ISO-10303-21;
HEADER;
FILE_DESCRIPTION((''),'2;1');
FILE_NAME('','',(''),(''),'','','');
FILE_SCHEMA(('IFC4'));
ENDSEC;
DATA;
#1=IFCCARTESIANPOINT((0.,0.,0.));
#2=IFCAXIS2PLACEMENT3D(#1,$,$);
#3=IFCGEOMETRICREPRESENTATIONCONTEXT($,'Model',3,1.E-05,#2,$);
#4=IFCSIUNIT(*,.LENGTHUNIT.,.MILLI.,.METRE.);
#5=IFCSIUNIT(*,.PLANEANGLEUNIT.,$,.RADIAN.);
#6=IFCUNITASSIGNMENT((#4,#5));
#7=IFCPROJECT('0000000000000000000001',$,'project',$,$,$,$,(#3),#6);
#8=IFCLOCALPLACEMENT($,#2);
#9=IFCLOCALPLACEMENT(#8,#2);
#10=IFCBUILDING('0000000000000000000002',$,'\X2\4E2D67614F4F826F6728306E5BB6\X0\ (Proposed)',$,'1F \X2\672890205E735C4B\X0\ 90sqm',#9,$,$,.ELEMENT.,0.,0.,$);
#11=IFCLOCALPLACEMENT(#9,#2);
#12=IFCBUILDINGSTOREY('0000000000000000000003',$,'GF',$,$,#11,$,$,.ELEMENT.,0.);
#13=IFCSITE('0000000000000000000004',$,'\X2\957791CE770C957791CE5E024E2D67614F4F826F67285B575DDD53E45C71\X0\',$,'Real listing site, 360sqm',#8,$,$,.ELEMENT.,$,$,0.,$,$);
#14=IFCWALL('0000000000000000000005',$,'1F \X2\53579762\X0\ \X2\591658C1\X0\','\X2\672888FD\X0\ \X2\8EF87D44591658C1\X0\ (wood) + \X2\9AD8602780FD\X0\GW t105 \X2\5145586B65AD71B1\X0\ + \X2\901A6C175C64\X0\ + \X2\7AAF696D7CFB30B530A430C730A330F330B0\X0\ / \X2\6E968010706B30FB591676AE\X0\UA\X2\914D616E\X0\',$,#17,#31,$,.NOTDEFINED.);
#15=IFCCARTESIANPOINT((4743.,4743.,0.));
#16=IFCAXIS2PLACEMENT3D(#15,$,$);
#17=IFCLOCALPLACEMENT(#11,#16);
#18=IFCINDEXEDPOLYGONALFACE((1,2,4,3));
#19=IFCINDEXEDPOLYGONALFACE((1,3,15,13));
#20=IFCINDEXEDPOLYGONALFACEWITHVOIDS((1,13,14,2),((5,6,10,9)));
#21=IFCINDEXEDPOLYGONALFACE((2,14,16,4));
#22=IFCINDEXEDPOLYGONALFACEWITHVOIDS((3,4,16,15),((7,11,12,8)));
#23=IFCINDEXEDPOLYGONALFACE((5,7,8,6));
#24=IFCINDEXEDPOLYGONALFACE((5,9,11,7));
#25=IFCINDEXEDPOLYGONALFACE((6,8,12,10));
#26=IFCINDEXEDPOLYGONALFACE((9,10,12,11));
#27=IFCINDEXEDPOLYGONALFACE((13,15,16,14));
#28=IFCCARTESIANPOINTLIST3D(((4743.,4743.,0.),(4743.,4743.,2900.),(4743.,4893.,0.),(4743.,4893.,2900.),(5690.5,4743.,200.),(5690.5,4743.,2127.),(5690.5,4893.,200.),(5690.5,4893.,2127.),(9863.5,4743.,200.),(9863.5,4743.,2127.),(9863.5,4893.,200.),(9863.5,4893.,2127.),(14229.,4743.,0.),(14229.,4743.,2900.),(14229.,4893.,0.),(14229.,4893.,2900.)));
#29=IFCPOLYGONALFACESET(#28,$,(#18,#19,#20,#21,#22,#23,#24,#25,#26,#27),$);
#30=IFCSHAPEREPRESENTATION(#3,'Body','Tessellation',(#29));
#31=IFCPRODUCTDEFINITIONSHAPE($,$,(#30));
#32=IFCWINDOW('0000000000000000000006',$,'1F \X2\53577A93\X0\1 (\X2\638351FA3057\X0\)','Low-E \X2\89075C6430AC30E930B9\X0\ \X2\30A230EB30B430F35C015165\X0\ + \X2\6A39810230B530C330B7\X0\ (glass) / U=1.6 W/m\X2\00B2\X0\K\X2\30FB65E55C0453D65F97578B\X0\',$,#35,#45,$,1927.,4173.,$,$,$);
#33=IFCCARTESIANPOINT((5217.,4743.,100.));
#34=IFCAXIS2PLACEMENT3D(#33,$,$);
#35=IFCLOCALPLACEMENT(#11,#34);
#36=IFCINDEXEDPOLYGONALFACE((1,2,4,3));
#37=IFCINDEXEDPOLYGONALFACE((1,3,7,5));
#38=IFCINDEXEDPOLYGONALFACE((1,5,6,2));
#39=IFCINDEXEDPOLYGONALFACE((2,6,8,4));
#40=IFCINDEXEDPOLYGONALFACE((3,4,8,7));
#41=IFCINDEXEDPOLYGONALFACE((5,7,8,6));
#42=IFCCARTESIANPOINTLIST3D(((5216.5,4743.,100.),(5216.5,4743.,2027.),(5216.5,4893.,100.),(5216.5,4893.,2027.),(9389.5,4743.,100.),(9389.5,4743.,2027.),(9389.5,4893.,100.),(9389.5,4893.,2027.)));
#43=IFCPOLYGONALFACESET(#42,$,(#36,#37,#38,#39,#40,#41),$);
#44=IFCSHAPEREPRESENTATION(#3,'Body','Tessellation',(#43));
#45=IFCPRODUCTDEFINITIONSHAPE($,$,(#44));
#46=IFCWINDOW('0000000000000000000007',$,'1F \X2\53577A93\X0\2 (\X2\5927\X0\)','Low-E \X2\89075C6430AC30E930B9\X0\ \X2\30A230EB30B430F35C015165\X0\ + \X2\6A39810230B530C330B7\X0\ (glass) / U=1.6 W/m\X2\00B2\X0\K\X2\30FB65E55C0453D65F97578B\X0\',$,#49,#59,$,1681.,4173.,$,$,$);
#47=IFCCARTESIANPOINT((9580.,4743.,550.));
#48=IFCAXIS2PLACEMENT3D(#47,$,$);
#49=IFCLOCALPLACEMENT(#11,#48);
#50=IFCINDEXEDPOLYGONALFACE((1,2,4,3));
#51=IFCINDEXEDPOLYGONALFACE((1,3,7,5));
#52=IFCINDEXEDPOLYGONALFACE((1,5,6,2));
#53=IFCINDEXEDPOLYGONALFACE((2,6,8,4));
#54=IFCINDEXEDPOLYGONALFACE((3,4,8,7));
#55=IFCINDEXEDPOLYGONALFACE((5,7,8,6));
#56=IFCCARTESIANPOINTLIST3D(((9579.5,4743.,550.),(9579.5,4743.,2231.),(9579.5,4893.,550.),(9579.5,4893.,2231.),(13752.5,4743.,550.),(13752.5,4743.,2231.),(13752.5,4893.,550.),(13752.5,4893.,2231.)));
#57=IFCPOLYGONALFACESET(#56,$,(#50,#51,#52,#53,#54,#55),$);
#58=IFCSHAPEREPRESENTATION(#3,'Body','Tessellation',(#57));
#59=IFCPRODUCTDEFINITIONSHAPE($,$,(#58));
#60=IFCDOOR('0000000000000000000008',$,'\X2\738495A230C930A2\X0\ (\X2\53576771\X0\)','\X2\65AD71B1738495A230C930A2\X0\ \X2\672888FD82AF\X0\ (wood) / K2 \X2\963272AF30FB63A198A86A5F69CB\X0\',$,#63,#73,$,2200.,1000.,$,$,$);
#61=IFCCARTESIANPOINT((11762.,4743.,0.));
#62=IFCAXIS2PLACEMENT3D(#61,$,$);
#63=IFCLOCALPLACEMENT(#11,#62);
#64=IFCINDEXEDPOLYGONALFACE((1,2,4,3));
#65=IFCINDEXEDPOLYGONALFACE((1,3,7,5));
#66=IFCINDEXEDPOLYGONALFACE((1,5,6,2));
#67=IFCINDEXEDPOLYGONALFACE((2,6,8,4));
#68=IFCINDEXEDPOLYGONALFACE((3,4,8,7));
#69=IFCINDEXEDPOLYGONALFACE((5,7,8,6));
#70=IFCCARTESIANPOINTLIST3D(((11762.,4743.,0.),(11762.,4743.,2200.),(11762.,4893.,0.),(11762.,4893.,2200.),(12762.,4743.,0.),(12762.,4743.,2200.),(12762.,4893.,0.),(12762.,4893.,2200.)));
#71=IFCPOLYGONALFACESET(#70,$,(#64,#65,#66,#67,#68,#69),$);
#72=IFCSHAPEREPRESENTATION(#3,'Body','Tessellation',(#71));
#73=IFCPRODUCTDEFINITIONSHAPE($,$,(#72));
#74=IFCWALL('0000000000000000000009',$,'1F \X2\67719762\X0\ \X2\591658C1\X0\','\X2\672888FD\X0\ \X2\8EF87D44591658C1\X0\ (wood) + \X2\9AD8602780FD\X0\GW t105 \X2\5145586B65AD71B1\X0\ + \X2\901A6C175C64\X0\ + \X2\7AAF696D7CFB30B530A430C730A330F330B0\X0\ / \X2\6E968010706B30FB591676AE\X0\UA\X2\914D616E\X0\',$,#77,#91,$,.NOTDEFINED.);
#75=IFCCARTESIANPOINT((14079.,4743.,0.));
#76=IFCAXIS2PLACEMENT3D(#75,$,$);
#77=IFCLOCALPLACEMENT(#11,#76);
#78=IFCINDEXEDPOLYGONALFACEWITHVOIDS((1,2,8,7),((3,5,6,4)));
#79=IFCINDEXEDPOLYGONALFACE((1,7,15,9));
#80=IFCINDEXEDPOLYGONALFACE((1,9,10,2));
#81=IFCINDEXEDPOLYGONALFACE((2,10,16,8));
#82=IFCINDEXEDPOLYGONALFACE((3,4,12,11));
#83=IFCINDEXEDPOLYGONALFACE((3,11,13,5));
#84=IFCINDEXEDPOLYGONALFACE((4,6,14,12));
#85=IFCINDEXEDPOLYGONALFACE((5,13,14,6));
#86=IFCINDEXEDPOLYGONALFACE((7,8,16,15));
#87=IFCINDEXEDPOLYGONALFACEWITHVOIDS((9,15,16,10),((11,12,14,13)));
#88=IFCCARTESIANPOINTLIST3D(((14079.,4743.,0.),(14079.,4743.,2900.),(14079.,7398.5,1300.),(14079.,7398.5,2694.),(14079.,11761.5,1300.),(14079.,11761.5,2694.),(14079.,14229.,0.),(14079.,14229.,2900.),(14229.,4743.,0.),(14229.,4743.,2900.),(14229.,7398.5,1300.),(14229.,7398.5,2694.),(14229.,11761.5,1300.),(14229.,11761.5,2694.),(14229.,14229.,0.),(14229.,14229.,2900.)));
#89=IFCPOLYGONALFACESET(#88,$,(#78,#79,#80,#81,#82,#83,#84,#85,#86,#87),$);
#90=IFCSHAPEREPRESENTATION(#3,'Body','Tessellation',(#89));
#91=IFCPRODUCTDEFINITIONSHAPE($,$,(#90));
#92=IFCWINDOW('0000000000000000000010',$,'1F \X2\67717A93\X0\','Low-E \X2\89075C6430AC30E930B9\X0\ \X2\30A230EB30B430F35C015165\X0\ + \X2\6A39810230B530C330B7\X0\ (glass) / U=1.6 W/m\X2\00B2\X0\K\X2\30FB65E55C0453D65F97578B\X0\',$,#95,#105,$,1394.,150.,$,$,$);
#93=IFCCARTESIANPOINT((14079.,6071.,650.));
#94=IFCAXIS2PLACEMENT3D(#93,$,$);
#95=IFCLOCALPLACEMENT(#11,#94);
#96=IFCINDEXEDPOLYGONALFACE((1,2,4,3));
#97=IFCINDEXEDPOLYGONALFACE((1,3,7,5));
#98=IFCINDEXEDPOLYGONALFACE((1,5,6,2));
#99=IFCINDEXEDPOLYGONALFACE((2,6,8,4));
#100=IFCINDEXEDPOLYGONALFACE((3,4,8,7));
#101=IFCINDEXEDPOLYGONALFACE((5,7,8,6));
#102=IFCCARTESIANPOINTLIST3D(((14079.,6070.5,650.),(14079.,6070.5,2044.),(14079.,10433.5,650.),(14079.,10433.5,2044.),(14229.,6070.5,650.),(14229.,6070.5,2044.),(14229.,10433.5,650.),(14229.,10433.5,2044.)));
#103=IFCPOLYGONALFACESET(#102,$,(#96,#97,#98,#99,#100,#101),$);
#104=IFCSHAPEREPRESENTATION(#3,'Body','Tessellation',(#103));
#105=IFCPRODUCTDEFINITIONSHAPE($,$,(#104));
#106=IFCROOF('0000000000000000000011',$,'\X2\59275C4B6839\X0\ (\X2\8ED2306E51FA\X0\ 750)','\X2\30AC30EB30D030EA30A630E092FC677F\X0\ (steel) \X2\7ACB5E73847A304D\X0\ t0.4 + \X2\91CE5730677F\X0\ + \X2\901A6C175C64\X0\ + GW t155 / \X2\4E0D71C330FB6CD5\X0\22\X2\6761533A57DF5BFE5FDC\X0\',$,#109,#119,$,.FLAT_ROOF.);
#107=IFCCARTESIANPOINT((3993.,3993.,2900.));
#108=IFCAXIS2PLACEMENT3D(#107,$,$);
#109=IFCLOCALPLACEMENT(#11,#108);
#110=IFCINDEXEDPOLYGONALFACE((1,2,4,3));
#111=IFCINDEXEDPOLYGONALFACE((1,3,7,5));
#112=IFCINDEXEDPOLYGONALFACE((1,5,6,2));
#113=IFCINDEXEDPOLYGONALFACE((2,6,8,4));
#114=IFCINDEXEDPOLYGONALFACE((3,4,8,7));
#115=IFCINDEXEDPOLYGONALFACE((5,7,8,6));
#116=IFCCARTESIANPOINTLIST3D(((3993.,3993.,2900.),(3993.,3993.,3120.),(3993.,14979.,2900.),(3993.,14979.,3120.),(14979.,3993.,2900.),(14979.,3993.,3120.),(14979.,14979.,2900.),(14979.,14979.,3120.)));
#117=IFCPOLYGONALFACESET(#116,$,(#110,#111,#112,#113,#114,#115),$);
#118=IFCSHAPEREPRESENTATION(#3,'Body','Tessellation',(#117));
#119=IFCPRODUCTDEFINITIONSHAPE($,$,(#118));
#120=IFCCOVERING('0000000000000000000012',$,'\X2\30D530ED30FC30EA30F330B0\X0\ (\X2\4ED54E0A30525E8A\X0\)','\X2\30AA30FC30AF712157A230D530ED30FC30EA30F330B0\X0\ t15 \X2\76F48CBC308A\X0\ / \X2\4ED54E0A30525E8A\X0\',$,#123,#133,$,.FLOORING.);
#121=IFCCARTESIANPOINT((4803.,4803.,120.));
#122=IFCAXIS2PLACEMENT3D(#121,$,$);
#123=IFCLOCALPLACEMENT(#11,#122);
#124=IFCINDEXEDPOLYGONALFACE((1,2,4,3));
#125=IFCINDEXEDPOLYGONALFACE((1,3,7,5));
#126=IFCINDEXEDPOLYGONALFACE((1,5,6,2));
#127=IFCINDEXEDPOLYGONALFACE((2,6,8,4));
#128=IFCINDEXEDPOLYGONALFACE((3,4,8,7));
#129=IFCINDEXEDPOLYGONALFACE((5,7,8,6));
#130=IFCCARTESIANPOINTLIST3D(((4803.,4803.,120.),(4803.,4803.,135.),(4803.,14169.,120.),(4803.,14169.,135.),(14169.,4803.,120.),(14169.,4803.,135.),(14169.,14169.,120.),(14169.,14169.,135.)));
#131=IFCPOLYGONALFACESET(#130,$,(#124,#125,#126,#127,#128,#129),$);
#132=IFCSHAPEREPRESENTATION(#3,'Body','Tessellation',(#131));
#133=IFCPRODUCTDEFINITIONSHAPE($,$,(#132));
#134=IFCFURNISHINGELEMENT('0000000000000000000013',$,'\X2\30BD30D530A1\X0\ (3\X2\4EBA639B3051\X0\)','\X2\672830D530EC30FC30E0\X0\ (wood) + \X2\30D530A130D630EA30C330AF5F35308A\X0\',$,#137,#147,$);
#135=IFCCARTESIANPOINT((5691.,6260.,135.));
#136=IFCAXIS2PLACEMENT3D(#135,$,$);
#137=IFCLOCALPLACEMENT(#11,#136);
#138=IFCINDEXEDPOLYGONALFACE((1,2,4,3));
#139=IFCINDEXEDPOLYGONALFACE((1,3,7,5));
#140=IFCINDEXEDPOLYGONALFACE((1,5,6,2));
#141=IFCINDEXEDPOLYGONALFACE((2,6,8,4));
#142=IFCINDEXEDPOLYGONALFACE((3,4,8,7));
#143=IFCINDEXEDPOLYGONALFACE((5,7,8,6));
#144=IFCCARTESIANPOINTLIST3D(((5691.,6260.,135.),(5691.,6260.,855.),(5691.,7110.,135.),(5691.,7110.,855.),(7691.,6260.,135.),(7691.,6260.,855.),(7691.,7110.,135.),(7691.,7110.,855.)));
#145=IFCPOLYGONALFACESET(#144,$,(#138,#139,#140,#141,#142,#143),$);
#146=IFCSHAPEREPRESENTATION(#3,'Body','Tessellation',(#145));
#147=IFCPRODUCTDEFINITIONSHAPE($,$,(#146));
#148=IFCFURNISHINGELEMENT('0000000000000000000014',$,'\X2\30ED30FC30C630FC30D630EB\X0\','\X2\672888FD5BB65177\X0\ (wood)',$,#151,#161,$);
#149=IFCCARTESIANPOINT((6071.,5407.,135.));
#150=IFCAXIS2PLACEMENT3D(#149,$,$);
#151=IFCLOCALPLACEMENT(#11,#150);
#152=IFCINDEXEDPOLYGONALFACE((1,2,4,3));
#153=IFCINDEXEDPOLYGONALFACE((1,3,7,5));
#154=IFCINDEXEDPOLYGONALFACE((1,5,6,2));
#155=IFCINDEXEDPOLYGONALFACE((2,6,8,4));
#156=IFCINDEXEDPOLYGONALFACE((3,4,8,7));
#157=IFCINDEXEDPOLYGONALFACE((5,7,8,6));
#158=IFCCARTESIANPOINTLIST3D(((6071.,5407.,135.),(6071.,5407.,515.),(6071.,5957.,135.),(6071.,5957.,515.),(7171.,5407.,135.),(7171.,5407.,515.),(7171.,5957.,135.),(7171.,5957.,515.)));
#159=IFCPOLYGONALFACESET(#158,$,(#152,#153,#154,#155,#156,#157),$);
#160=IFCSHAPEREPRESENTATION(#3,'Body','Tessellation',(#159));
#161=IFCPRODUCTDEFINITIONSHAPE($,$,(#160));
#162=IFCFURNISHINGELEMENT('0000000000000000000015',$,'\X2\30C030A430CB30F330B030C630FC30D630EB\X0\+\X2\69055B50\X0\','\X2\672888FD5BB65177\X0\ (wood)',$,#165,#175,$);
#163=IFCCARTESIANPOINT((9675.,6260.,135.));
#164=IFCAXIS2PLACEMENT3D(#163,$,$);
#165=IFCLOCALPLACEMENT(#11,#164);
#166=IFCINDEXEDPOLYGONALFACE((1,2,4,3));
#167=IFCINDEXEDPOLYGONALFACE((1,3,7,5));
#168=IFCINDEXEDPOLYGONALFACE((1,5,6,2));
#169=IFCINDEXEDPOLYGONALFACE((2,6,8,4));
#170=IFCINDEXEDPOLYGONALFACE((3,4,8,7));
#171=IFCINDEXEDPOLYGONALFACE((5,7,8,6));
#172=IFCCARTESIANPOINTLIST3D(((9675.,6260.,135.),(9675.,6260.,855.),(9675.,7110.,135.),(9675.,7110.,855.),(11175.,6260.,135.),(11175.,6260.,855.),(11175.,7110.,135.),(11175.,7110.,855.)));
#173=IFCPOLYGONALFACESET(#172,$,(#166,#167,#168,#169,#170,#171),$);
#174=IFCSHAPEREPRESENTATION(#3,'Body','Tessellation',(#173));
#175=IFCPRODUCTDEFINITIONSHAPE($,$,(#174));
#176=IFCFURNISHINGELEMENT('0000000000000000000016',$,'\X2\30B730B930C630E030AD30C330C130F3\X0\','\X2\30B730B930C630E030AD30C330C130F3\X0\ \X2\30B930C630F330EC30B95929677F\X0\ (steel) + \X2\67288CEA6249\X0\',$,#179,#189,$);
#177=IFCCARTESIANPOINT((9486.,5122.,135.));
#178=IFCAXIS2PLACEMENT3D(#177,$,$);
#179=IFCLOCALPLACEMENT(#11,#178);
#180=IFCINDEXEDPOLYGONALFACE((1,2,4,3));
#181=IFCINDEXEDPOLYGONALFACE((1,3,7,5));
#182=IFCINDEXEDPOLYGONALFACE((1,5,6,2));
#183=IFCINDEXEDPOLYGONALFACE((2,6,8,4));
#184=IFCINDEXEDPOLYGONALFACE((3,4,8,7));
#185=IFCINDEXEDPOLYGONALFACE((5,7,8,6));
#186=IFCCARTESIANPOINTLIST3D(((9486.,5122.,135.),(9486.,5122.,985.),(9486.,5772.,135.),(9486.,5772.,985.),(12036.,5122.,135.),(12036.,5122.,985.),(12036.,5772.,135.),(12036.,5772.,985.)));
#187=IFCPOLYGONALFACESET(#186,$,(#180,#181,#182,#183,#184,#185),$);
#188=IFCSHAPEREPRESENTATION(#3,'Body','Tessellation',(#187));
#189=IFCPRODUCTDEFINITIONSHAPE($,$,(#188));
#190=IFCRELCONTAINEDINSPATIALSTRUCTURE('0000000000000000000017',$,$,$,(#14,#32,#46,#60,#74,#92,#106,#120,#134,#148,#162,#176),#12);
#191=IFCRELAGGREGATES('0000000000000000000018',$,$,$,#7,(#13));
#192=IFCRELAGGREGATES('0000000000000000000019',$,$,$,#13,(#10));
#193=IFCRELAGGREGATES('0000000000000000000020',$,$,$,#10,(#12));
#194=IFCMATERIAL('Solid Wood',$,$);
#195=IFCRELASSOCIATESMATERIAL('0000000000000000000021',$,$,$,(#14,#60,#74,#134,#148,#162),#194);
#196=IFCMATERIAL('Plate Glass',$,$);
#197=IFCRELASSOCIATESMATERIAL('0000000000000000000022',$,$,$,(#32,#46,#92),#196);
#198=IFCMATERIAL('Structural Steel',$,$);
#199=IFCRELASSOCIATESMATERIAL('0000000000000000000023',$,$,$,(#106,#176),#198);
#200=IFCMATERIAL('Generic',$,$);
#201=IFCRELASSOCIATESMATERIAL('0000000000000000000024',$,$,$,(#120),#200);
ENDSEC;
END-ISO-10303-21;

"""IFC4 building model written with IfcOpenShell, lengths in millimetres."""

from ifc_helpers import new_model, si_unit, frame, frame_2d, origin, place, context, project, spatial, rectangle, extrude, material, element, fill, save


model = new_model("IFC4")

# Units and contexts
model_context = context("Model", 3, precision=1e-05, world=origin())
ifc_project = project(units=[si_unit("LENGTHUNIT", "METRE", prefix="MILLI"), si_unit("PLANEANGLEUNIT", "RADIAN")], contexts=[model_context])

# Site, building, storey
site_placement = place(None, origin())
site = spatial("IfcSite", under=ifc_project, at=site_placement, Name="長野県長野市中条住良木字川古山", ObjectType="Real listing site, 360sqm", CompositionType="ELEMENT", RefElevation=0.0)
building_placement = place(site_placement, origin())
building = spatial("IfcBuilding", under=site, at=building_placement, Name="中条住良木の家 (Proposed)", ObjectType="1F 木造平屋 90sqm", CompositionType="ELEMENT", ElevationOfRefHeight=0.0, ElevationOfTerrain=0.0)
storey_placement = place(building_placement, origin())
storey = spatial("IfcBuildingStorey", under=building, at=storey_placement, Name="GF", CompositionType="ELEMENT", Elevation=0.0)

# Shared definitions
ifc_material_1 = material(Name="Solid Wood")

# Wall, openings, windows, door
wall_1_placement = place(storey_placement, frame((4743.0, 4743.0, 0.0)))
wall_1 = element("IfcWall", 1, at=wall_1_placement, inside=storey, material=ifc_material_1, Name="1F 南面 外壁", Description="木製 軸組外壁 (wood) + 高性能GW t105 充填断熱 + 通気層 + 窯業系サイディング / 準耐火・外皮UA配慮", PredefinedType="NOTDEFINED", context=model_context, shape_type="SweptSolid", body=[
    extrude(rectangle(XDim=9486.0, YDim=150.0, at=frame_2d((4743.0, 75.0))), frame((4743.0, 4743.0, 0.0)), (0.0, 0.0, 1.0), 2900.0),
])
opening_1_placement = place(storey_placement, frame((5217.0, 4743.0, 100.0)))
opening_1 = element("IfcOpeningElement", 2, at=opening_1_placement, cuts=wall_1, PredefinedType="NOTDEFINED", context=model_context, shape_type="SweptSolid", body=[
    extrude(rectangle(XDim=4173.0, YDim=150.0, at=frame_2d((2086.0, 75.0))), frame((5217.0, 4743.0, 100.0)), (0.0, 0.0, 1.0), 1927.0),
])
opening_2_placement = place(storey_placement, frame((9580.0, 4743.0, 550.0)))
opening_2 = element("IfcOpeningElement", 3, at=opening_2_placement, cuts=wall_1, PredefinedType="NOTDEFINED", context=model_context, shape_type="SweptSolid", body=[
    extrude(rectangle(XDim=4173.0, YDim=150.0, at=frame_2d((2086.0, 75.0))), frame((9580.0, 4743.0, 550.0)), (0.0, 0.0, 1.0), 1681.0),
])
opening_3_placement = place(storey_placement, frame((11762.0, 4743.0, 0.0)))
opening_3 = element("IfcOpeningElement", 4, at=opening_3_placement, cuts=wall_1, PredefinedType="NOTDEFINED", context=model_context, shape_type="SweptSolid", body=[
    extrude(rectangle(XDim=1000.0, YDim=150.0, at=frame_2d((500.0, 75.0))), frame((11762.0, 4743.0, 0.0)), (0.0, 0.0, 1.0), 2200.0),
])
ifc_material_2 = material(Name="Plate Glass")
window_1_placement = place(storey_placement, frame((5217.0, 4743.0, 100.0)))
window_1 = element("IfcWindow", 5, at=window_1_placement, inside=storey, material=ifc_material_2, Name="1F 南窓1 (掃出し)", Description="Low-E 複層ガラス アルゴン封入 + 樹脂サッシ (glass) / U=1.6 W/m²K・日射取得型", OverallHeight=1927.0, OverallWidth=4173.0, context=model_context, shape_type="SweptSolid", body=[
    extrude(rectangle(XDim=4173.0, YDim=150.0, at=frame_2d((2086.0, 75.0))), frame((5217.0, 4743.0, 100.0)), (0.0, 0.0, 1.0), 1927.0),
])
fill(opening_1, window_1)
window_2_placement = place(storey_placement, frame((9580.0, 4743.0, 550.0)))
window_2 = element("IfcWindow", 6, at=window_2_placement, inside=storey, material=ifc_material_2, Name="1F 南窓2 (大)", Description="Low-E 複層ガラス アルゴン封入 + 樹脂サッシ (glass) / U=1.6 W/m²K・日射取得型", OverallHeight=1681.0, OverallWidth=4173.0, context=model_context, shape_type="SweptSolid", body=[
    extrude(rectangle(XDim=4173.0, YDim=150.0, at=frame_2d((2086.0, 75.0))), frame((9580.0, 4743.0, 550.0)), (0.0, 0.0, 1.0), 1681.0),
])
fill(opening_2, window_2)
door_placement = place(storey_placement, frame((11762.0, 4743.0, 0.0)))
door = element("IfcDoor", 7, at=door_placement, inside=storey, material=ifc_material_1, Name="玄関ドア (南東)", Description="断熱玄関ドア 木製芯 (wood) / K2 防犯・採風機構", OverallHeight=2200.0, OverallWidth=1000.0, context=model_context, shape_type="SweptSolid", body=[
    extrude(rectangle(XDim=1000.0, YDim=150.0, at=frame_2d((500.0, 75.0))), frame((11762.0, 4743.0, 0.0)), (0.0, 0.0, 1.0), 2200.0),
])
fill(opening_3, door)

# Wall, opening, window
wall_2_placement = place(storey_placement, frame((14079.0, 4743.0, 0.0)))
wall_2 = element("IfcWall", 8, at=wall_2_placement, inside=storey, material=ifc_material_1, Name="1F 東面 外壁", Description="木製 軸組外壁 (wood) + 高性能GW t105 充填断熱 + 通気層 + 窯業系サイディング / 準耐火・外皮UA配慮", PredefinedType="NOTDEFINED", context=model_context, shape_type="SweptSolid", body=[
    extrude(rectangle(XDim=150.0, YDim=9486.0, at=frame_2d((75.0, 4743.0))), frame((14079.0, 4743.0, 0.0)), (0.0, 0.0, 1.0), 2900.0),
])
opening_4_placement = place(storey_placement, frame((14079.0, 6071.0, 650.0)))
opening_4 = element("IfcOpeningElement", 9, at=opening_4_placement, cuts=wall_2, PredefinedType="NOTDEFINED", context=model_context, shape_type="SweptSolid", body=[
    extrude(rectangle(XDim=150.0, YDim=4363.0, at=frame_2d((75.0, 2181.0))), frame((14079.0, 6071.0, 650.0)), (0.0, 0.0, 1.0), 1394.0),
])
window_3_placement = place(storey_placement, frame((14079.0, 6071.0, 650.0)))
window_3 = element("IfcWindow", 10, at=window_3_placement, inside=storey, material=ifc_material_2, Name="1F 東窓", Description="Low-E 複層ガラス アルゴン封入 + 樹脂サッシ (glass) / U=1.6 W/m²K・日射取得型", OverallHeight=1394.0, OverallWidth=150.0, context=model_context, shape_type="SweptSolid", body=[
    extrude(rectangle(XDim=150.0, YDim=4363.0, at=frame_2d((75.0, 2181.0))), frame((14079.0, 6071.0, 650.0)), (0.0, 0.0, 1.0), 1394.0),
])
fill(opening_4, window_3)

# Roof
ifc_material_3 = material(Name="Structural Steel")
roof_placement = place(storey_placement, frame((3993.0, 3993.0, 2900.0)))
element("IfcRoof", 11, at=roof_placement, inside=storey, material=ifc_material_3, Name="大屋根 (軒の出 750)", Description="ガルバリウム鋼板 (steel) 立平葺き t0.4 + 野地板 + 通気層 + GW t155 / 不燃・法22条区域対応", PredefinedType="FLAT_ROOF", context=model_context, shape_type="SweptSolid", body=[
    extrude(rectangle(XDim=10986.0, YDim=10986.0, at=frame_2d((5493.0, 5493.0))), frame((3993.0, 3993.0, 2900.0)), (0.0, 0.0, 1.0), 220.0),
])

# Covering
ifc_material_4 = material(Name="Generic")
covering_placement = place(storey_placement, frame((4803.0, 4803.0, 120.0)))
element("IfcCovering", 12, at=covering_placement, inside=storey, material=ifc_material_4, Name="フローリング (仕上げ床)", Description="オーク無垢フローリング t15 直貼り / 仕上げ床", PredefinedType="FLOORING", context=model_context, shape_type="SweptSolid", body=[
    extrude(rectangle(XDim=9366.0, YDim=9366.0, at=frame_2d((4683.0, 4683.0))), frame((4803.0, 4803.0, 120.0)), (0.0, 0.0, 1.0), 15.0),
])

# Furnishing elements
furnishing_1_placement = place(storey_placement, frame((5691.0, 6260.0, 135.0)))
element("IfcFurnishingElement", 13, at=furnishing_1_placement, inside=storey, material=ifc_material_1, Name="ソファ (3人掛け)", Description="木フレーム (wood) + ファブリック張り", context=model_context, shape_type="SweptSolid", body=[
    extrude(rectangle(XDim=2000.0, YDim=850.0, at=frame_2d((1000.0, 425.0))), frame((5691.0, 6260.0, 135.0)), (0.0, 0.0, 1.0), 720.0),
])
furnishing_2_placement = place(storey_placement, frame((6071.0, 5407.0, 135.0)))
element("IfcFurnishingElement", 14, at=furnishing_2_placement, inside=storey, material=ifc_material_1, Name="ローテーブル", Description="木製家具 (wood)", context=model_context, shape_type="SweptSolid", body=[
    extrude(rectangle(XDim=1100.0, YDim=550.0, at=frame_2d((550.0, 275.0))), frame((6071.0, 5407.0, 135.0)), (0.0, 0.0, 1.0), 380.0),
])
furnishing_3_placement = place(storey_placement, frame((9675.0, 6260.0, 135.0)))
element("IfcFurnishingElement", 15, at=furnishing_3_placement, inside=storey, material=ifc_material_1, Name="ダイニングテーブル+椅子", Description="木製家具 (wood)", context=model_context, shape_type="SweptSolid", body=[
    extrude(rectangle(XDim=1500.0, YDim=850.0, at=frame_2d((750.0, 425.0))), frame((9675.0, 6260.0, 135.0)), (0.0, 0.0, 1.0), 720.0),
])
furnishing_4_placement = place(storey_placement, frame((9486.0, 5122.0, 135.0)))
element("IfcFurnishingElement", 16, at=furnishing_4_placement, inside=storey, material=ifc_material_3, Name="システムキッチン", Description="システムキッチン ステンレス天板 (steel) + 木質扉", context=model_context, shape_type="SweptSolid", body=[
    extrude(rectangle(XDim=2550.0, YDim=650.0, at=frame_2d((1275.0, 325.0))), frame((9486.0, 5122.0, 135.0)), (0.0, 0.0, 1.0), 850.0),
])

save(model, "model.ifc")
